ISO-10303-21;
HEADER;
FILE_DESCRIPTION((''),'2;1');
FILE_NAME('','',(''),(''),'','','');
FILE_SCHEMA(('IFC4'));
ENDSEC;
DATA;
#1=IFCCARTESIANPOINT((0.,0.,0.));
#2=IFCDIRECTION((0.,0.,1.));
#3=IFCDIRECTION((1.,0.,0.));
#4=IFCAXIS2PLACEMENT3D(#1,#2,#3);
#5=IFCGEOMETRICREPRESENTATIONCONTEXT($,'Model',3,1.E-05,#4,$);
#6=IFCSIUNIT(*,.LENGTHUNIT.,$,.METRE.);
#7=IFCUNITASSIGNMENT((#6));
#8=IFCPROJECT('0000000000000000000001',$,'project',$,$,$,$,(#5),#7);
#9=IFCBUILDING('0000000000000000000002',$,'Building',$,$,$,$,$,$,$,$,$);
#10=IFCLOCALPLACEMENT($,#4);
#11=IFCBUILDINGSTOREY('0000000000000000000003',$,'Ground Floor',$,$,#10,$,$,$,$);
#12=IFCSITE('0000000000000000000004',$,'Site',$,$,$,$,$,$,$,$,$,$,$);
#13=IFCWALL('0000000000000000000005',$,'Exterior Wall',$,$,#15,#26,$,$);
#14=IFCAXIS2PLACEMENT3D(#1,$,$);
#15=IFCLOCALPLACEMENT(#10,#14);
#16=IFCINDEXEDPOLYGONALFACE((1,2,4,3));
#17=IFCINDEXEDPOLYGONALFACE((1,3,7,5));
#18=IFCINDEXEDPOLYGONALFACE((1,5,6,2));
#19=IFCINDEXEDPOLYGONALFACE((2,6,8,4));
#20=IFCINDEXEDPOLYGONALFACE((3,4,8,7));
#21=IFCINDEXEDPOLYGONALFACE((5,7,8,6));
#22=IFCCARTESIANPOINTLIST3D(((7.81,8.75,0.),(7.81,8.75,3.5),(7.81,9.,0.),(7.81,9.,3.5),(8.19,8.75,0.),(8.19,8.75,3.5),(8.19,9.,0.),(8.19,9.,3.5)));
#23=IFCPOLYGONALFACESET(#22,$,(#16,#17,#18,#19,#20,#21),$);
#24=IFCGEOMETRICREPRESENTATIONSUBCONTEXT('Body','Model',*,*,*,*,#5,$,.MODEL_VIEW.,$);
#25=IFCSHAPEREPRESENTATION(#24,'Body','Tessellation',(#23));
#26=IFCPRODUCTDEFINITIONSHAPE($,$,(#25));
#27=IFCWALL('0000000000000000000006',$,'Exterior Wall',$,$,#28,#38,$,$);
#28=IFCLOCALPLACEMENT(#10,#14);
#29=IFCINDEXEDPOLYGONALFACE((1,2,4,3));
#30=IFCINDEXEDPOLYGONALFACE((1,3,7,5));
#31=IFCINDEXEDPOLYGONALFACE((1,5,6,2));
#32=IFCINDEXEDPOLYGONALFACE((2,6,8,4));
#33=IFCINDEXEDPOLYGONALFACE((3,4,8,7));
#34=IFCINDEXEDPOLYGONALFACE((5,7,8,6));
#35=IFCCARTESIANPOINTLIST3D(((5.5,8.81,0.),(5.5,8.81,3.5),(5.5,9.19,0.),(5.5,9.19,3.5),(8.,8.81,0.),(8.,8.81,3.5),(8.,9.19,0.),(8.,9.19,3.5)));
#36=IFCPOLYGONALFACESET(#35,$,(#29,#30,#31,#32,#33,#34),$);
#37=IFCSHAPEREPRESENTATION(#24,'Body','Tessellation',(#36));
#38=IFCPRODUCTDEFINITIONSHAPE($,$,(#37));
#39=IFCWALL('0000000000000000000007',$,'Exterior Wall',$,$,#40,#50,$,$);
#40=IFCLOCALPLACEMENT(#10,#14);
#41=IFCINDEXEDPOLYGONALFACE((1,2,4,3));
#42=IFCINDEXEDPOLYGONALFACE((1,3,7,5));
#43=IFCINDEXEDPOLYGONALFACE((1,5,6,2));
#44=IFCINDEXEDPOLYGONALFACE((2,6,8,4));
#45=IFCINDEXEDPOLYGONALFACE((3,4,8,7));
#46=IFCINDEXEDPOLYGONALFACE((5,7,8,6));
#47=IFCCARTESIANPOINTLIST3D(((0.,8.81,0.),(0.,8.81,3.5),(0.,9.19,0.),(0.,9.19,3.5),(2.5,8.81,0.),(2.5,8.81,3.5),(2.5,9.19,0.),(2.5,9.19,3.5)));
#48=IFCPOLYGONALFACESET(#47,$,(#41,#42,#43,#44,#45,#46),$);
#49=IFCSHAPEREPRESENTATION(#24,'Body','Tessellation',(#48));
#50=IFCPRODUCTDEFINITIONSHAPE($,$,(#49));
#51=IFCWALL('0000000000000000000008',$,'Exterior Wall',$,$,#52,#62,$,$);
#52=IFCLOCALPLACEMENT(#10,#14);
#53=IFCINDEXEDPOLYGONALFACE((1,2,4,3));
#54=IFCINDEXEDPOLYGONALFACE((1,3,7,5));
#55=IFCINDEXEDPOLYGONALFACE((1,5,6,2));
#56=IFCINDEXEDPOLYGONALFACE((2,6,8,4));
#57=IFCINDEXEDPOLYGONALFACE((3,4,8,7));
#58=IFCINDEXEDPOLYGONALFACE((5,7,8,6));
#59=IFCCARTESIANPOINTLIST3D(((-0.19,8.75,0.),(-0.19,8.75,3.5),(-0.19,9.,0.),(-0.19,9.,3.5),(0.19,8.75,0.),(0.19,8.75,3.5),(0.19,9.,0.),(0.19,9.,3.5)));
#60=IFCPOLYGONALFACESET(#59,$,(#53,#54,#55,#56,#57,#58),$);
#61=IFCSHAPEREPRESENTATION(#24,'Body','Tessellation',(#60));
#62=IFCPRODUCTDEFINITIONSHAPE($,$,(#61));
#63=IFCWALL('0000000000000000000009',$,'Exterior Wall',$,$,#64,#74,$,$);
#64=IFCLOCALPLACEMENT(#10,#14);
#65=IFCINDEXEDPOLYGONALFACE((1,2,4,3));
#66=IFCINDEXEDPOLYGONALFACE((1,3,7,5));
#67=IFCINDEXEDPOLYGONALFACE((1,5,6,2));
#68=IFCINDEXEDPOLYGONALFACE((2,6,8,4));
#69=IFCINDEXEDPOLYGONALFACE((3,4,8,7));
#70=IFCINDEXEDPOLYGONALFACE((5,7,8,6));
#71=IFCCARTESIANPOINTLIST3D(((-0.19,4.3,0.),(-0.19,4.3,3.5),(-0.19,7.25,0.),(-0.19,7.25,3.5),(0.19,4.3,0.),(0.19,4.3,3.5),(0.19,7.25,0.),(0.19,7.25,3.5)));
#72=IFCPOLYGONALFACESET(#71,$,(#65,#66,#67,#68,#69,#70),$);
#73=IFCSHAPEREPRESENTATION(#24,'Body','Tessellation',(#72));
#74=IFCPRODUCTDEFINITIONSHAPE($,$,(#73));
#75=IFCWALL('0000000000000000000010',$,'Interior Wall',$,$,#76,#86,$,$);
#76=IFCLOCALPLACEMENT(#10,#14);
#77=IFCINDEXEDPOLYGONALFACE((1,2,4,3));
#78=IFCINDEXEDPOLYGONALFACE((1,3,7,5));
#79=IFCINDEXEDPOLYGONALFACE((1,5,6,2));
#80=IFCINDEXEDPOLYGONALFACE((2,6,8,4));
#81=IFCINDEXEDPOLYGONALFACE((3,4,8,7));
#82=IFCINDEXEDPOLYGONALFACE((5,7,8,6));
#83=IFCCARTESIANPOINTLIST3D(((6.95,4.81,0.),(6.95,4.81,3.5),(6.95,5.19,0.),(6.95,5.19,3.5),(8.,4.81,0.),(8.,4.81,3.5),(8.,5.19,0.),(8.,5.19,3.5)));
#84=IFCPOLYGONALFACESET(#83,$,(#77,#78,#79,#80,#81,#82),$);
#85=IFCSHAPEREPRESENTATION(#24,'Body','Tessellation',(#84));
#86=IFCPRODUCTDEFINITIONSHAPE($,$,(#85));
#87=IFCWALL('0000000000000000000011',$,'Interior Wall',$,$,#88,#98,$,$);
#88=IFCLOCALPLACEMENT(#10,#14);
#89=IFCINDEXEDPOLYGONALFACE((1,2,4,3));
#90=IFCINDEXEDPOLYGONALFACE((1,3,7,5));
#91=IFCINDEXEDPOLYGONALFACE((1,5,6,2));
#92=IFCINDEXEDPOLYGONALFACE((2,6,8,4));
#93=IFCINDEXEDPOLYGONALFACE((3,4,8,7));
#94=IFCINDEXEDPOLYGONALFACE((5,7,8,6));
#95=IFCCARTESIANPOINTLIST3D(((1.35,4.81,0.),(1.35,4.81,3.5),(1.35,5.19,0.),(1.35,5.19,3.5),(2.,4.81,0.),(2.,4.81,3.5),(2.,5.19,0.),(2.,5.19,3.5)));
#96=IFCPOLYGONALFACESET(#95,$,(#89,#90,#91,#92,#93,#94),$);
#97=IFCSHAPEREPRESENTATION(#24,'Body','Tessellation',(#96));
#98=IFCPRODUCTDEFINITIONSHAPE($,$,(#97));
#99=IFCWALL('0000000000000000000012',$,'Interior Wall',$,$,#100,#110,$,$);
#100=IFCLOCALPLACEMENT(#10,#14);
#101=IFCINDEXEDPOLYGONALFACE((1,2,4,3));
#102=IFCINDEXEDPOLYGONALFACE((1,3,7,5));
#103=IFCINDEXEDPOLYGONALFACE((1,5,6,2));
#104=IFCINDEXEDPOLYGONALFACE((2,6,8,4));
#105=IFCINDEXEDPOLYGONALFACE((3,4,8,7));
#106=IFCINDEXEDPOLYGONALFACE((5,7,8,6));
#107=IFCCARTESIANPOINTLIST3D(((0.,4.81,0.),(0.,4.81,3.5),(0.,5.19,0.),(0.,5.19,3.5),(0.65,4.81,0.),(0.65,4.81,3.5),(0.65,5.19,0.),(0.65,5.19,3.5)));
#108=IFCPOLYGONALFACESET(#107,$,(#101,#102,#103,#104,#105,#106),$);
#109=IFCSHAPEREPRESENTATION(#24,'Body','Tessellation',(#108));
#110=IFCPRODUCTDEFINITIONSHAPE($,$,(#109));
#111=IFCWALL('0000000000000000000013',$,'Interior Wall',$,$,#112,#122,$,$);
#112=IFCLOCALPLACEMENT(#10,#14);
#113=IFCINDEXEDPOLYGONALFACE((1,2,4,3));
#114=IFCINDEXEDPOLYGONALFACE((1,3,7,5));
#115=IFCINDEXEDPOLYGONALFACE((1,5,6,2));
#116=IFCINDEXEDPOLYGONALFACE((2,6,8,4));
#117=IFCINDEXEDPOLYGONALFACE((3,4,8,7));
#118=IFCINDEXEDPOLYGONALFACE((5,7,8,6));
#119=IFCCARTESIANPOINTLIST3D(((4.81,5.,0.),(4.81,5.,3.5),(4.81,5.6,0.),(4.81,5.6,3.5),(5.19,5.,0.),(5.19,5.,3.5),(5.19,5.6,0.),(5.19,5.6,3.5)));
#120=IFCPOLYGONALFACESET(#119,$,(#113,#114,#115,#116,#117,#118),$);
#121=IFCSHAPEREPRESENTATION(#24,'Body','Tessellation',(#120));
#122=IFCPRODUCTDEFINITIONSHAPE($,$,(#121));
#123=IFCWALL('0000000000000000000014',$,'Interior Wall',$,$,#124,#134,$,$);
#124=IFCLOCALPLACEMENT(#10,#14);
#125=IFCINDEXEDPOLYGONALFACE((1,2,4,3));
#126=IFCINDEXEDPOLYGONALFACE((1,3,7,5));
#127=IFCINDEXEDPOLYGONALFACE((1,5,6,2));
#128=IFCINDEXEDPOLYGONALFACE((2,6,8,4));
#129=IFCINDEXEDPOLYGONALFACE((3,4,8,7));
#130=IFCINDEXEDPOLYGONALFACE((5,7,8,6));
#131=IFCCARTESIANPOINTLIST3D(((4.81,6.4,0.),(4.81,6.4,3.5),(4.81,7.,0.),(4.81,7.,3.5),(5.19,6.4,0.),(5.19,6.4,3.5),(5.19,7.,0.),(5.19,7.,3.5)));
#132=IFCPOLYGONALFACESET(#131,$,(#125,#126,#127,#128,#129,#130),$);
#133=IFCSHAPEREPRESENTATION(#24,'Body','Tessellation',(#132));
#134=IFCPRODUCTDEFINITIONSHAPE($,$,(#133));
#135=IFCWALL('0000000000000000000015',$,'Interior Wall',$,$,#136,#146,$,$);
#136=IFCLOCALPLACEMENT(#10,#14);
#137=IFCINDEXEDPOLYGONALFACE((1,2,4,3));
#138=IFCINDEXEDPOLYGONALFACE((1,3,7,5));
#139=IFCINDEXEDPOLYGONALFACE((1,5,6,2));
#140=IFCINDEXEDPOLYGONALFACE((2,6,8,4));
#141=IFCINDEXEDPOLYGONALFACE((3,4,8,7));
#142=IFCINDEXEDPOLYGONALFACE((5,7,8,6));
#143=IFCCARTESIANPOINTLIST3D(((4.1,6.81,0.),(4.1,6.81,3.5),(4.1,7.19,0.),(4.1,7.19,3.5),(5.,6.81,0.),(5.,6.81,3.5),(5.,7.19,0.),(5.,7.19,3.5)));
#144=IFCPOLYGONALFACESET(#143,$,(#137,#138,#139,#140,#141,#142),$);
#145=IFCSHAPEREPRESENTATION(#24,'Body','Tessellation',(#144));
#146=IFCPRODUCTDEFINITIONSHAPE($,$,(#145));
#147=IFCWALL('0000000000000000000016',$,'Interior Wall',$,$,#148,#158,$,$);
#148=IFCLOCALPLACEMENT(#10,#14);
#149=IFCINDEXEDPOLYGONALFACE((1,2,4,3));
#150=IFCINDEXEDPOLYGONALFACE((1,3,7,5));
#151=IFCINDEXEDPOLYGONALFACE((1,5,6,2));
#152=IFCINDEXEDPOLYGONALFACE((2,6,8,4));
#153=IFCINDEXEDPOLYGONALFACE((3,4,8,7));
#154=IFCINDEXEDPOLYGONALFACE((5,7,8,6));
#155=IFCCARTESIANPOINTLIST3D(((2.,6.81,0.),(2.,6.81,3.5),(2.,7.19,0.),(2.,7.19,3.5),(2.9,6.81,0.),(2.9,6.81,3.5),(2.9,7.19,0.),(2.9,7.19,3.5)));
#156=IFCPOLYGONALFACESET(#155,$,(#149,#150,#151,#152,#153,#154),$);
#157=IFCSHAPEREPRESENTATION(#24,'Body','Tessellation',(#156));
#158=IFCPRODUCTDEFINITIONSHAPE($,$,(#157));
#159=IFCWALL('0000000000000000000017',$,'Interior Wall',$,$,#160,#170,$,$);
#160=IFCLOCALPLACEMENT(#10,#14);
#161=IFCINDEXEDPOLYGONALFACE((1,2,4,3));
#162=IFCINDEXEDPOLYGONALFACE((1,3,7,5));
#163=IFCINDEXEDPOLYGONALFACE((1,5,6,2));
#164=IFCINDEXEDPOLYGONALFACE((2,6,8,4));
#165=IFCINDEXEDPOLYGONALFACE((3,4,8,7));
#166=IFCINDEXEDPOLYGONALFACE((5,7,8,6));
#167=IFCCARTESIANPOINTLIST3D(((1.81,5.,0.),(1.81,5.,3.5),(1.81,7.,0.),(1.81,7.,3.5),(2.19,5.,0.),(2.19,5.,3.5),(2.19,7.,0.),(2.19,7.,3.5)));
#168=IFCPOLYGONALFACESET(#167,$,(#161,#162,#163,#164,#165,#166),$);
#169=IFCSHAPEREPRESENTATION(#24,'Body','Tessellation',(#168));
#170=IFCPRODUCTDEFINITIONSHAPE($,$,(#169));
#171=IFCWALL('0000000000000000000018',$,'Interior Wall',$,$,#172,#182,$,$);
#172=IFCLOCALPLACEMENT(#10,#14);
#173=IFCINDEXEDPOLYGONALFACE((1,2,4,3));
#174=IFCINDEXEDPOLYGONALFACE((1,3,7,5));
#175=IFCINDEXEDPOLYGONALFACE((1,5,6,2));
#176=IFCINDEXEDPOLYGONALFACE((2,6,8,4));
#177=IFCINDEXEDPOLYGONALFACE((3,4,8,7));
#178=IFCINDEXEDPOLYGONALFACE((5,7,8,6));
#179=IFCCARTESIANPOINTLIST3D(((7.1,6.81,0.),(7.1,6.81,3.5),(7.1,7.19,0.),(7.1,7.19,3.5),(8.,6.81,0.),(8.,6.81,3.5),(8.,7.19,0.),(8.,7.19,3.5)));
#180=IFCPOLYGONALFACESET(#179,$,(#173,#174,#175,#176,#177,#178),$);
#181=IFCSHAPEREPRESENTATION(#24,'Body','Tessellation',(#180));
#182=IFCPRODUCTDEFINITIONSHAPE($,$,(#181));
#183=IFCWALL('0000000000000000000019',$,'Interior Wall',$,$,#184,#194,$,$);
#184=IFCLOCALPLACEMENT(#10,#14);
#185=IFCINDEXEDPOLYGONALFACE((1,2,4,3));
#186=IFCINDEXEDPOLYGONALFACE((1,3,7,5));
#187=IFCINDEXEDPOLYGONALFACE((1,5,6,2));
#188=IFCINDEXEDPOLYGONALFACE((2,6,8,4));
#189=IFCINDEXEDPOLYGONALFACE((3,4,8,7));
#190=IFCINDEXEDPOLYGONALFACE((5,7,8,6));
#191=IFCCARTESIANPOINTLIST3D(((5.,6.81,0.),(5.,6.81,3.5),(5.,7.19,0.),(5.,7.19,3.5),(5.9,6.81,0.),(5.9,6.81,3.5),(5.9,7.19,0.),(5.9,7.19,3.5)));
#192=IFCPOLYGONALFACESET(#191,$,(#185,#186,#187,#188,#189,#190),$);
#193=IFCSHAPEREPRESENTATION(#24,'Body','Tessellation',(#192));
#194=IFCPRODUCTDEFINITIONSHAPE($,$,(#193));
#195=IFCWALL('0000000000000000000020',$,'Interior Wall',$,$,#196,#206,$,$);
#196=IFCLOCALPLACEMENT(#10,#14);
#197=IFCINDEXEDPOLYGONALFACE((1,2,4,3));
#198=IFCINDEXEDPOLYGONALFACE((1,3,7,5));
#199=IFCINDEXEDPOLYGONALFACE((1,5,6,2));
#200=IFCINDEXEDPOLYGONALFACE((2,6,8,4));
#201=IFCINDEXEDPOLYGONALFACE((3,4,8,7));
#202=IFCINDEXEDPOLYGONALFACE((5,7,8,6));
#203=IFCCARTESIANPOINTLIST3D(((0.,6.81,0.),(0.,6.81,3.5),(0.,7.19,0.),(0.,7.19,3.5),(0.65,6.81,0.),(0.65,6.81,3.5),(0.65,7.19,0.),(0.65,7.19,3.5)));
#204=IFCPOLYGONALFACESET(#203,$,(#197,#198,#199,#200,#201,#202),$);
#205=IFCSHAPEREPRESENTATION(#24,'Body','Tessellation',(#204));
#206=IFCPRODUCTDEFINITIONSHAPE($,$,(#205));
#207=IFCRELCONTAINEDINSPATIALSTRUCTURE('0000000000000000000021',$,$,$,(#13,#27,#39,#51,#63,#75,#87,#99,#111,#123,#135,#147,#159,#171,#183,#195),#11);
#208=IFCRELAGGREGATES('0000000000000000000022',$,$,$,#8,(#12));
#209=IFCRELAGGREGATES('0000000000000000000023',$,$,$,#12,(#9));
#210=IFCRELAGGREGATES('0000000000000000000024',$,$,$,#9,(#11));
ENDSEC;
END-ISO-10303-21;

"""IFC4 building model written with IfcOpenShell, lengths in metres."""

from ifc_helpers import new_model, si_unit, frame, origin_with_axes, place, context, subcontext, project, spatial, indexed_curve, outline, extrude, element, save


model = new_model("IFC4")

# Units and contexts
model_context = context("Model", 3, precision=1e-05, world=origin_with_axes())
body_context = subcontext(model_context, "Body", "Model", "MODEL_VIEW")
ifc_project = project(units=[si_unit("LENGTHUNIT", "METRE")], contexts=[model_context])

# Site, building, storey
site = spatial("IfcSite", under=ifc_project, Name="Site")
building = spatial("IfcBuilding", under=site, Name="Building")
storey_placement = place(None, origin_with_axes())
storey = spatial("IfcBuildingStorey", under=building, at=storey_placement, Name="Ground Floor")

# Walls
wall_1_placement = place(storey_placement, frame((8.0, 8.75, 0.0), z_axis=(0.0, 0.0, 1.0), x_axis=(0.0, 1.0, 0.0)))
element("IfcWall", 1, at=wall_1_placement, inside=storey, Name="Exterior Wall", context=body_context, shape_type="SweptSolid", body=[
    extrude(outline(indexed_curve([(0.0, 0.0), (0.0, 0.38), (0.25, 0.38), (0.25, 0.0), (0.0, 0.0)], self_intersect=False)), frame((0.0, -0.19, 0.0), z_axis=(0.0, 0.0, 1.0), x_axis=(1.0, 0.0, 0.0)), (0.0, 0.0, 1.0), 3.5),
])
for number, where, z_axis, x_axis, name in (
    (2, (8.0, 9.0, 0.0), (0.0, 0.0, 1.0), (-1.0, 0.0, 0.0), "Exterior Wall"),
    (3, (2.5, 9.0, 0.0), (0.0, 0.0, 1.0), (-1.0, 0.0, 0.0), "Exterior Wall"),
):
    element("IfcWall", number, at=place(storey_placement, frame(where, z_axis=z_axis, x_axis=x_axis)), inside=storey, Name=name, context=body_context, shape_type="SweptSolid", body=[
        extrude(outline(indexed_curve([(0.0, 0.0), (0.0, 0.38), (2.5, 0.38), (2.5, 0.0), (0.0, 0.0)], self_intersect=False)), frame((0.0, -0.19, 0.0), z_axis=(0.0, 0.0, 1.0), x_axis=(1.0, 0.0, 0.0)), (0.0, 0.0, 1.0), 3.5),
    ])
wall_2_placement = place(storey_placement, frame((0.0, 9.0, 0.0), z_axis=(0.0, 0.0, 1.0), x_axis=(0.0, -1.0, 0.0)))
element("IfcWall", 4, at=wall_2_placement, inside=storey, Name="Exterior Wall", context=body_context, shape_type="SweptSolid", body=[
    extrude(outline(indexed_curve([(0.0, 0.0), (0.0, 0.38), (0.25, 0.38), (0.25, 0.0), (0.0, 0.0)], self_intersect=False)), frame((0.0, -0.19, 0.0), z_axis=(0.0, 0.0, 1.0), x_axis=(1.0, 0.0, 0.0)), (0.0, 0.0, 1.0), 3.5),
])
wall_3_placement = place(storey_placement, frame((0.0, 7.25, 0.0), z_axis=(0.0, 0.0, 1.0), x_axis=(0.0, -1.0, 0.0)))
element("IfcWall", 5, at=wall_3_placement, inside=storey, Name="Exterior Wall", context=body_context, shape_type="SweptSolid", body=[
    extrude(outline(indexed_curve([(0.0, 0.0), (0.0, 0.38), (2.95, 0.38), (2.95, 0.0), (0.0, 0.0)], self_intersect=False)), frame((0.0, -0.19, 0.0), z_axis=(0.0, 0.0, 1.0), x_axis=(1.0, 0.0, 0.0)), (0.0, 0.0, 1.0), 3.5),
])
wall_4_placement = place(storey_placement, frame((8.0, 5.0, 0.0), z_axis=(0.0, 0.0, 1.0), x_axis=(-1.0, 0.0, 0.0)))
element("IfcWall", 6, at=wall_4_placement, inside=storey, Name="Interior Wall", context=body_context, shape_type="SweptSolid", body=[
    extrude(outline(indexed_curve([(0.0, 0.0), (0.0, 0.38), (1.05, 0.38), (1.05, 0.0), (0.0, 0.0)], self_intersect=False)), frame((0.0, -0.19, 0.0), z_axis=(0.0, 0.0, 1.0), x_axis=(1.0, 0.0, 0.0)), (0.0, 0.0, 1.0), 3.5),
])
for number, where, z_axis, x_axis, name in (
    (7, (2.0, 5.0, 0.0), (0.0, 0.0, 1.0), (-1.0, 0.0, 0.0), "Interior Wall"),
    (8, (0.65, 5.0, 0.0), (0.0, 0.0, 1.0), (-1.0, 0.0, 0.0), "Interior Wall"),
):
    element("IfcWall", number, at=place(storey_placement, frame(where, z_axis=z_axis, x_axis=x_axis)), inside=storey, Name=name, context=body_context, shape_type="SweptSolid", body=[
        extrude(outline(indexed_curve([(0.0, 0.0), (0.0, 0.38), (0.65, 0.38), (0.65, 0.0), (0.0, 0.0)], self_intersect=False)), frame((0.0, -0.19, 0.0), z_axis=(0.0, 0.0, 1.0), x_axis=(1.0, 0.0, 0.0)), (0.0, 0.0, 1.0), 3.5),
    ])
for number, where, z_axis, x_axis, name in (
    (9, (5.0, 5.0, 0.0), (0.0, 0.0, 1.0), (0.0, 1.0, 0.0), "Interior Wall"),
    (10, (5.0, 6.4, 0.0), (0.0, 0.0, 1.0), (0.0, 1.0, 0.0), "Interior Wall"),
):
    element("IfcWall", number, at=place(storey_placement, frame(where, z_axis=z_axis, x_axis=x_axis)), inside=storey, Name=name, context=body_context, shape_type="SweptSolid", body=[
        extrude(outline(indexed_curve([(0.0, 0.0), (0.0, 0.38), (0.6, 0.38), (0.6, 0.0), (0.0, 0.0)], self_intersect=False)), frame((0.0, -0.19, 0.0), z_axis=(0.0, 0.0, 1.0), x_axis=(1.0, 0.0, 0.0)), (0.0, 0.0, 1.0), 3.5),
    ])
wall_5_placement = place(storey_placement, frame((5.0, 7.0, 0.0), z_axis=(0.0, 0.0, 1.0), x_axis=(-1.0, 0.0, 0.0)))
element("IfcWall", 11, at=wall_5_placement, inside=storey, Name="Interior Wall", context=body_context, shape_type="SweptSolid", body=[
    extrude(outline(indexed_curve([(0.0, 0.0), (0.0, 0.38), (0.9, 0.38), (0.9, 0.0), (0.0, 0.0)], self_intersect=False)), frame((0.0, -0.19, 0.0), z_axis=(0.0, 0.0, 1.0), x_axis=(1.0, 0.0, 0.0)), (0.0, 0.0, 1.0), 3.5),
])
wall_6_placement = place(storey_placement, frame((2.9, 7.0, 0.0), z_axis=(0.0, 0.0, 1.0), x_axis=(-1.0, 0.0, 0.0)))
element("IfcWall", 12, at=wall_6_placement, inside=storey, Name="Interior Wall", context=body_context, shape_type="SweptSolid", body=[
    extrude(outline(indexed_curve([(0.0, 0.0), (0.0, 0.38), (0.9, 0.38), (0.9, 0.0), (0.0, 0.0)], self_intersect=False)), frame((0.0, -0.19, 0.0), z_axis=(0.0, 0.0, 1.0), x_axis=(1.0, 0.0, 0.0)), (0.0, 0.0, 1.0), 3.5),
])
wall_7_placement = place(storey_placement, frame((2.0, 7.0, 0.0), z_axis=(0.0, 0.0, 1.0), x_axis=(0.0, -1.0, 0.0)))
element("IfcWall", 13, at=wall_7_placement, inside=storey, Name="Interior Wall", context=body_context, shape_type="SweptSolid", body=[
    extrude(outline(indexed_curve([(0.0, 0.0), (0.0, 0.38), (2.0, 0.38), (2.0, 0.0), (0.0, 0.0)], self_intersect=False)), frame((0.0, -0.19, 0.0), z_axis=(0.0, 0.0, 1.0), x_axis=(1.0, 0.0, 0.0)), (0.0, 0.0, 1.0), 3.5),
])
for number, where, z_axis, x_axis, name in (
    (14, (8.0, 7.0, 0.0), (0.0, 0.0, 1.0), (-1.0, 0.0, 0.0), "Interior Wall"),
    (15, (5.9, 7.0, 0.0), (0.0, 0.0, 1.0), (-1.0, 0.0, 0.0), "Interior Wall"),
):
    element("IfcWall", number, at=place(storey_placement, frame(where, z_axis=z_axis, x_axis=x_axis)), inside=storey, Name=name, context=body_context, shape_type="SweptSolid", body=[
        extrude(outline(indexed_curve([(0.0, 0.0), (0.0, 0.38), (0.9, 0.38), (0.9, 0.0), (0.0, 0.0)], self_intersect=False)), frame((0.0, -0.19, 0.0), z_axis=(0.0, 0.0, 1.0), x_axis=(1.0, 0.0, 0.0)), (0.0, 0.0, 1.0), 3.5),
    ])
wall_8_placement = place(storey_placement, frame((0.0, 7.0, 0.0), z_axis=(0.0, 0.0, 1.0), x_axis=(1.0, 0.0, 0.0)))
element("IfcWall", 16, at=wall_8_placement, inside=storey, Name="Interior Wall", context=body_context, shape_type="SweptSolid", body=[
    extrude(outline(indexed_curve([(0.0, 0.0), (0.0, 0.38), (0.65, 0.38), (0.65, 0.0), (0.0, 0.0)], self_intersect=False)), frame((0.0, -0.19, 0.0), z_axis=(0.0, 0.0, 1.0), x_axis=(1.0, 0.0, 0.0)), (0.0, 0.0, 1.0), 3.5),
])

save(model, "model.ifc")
